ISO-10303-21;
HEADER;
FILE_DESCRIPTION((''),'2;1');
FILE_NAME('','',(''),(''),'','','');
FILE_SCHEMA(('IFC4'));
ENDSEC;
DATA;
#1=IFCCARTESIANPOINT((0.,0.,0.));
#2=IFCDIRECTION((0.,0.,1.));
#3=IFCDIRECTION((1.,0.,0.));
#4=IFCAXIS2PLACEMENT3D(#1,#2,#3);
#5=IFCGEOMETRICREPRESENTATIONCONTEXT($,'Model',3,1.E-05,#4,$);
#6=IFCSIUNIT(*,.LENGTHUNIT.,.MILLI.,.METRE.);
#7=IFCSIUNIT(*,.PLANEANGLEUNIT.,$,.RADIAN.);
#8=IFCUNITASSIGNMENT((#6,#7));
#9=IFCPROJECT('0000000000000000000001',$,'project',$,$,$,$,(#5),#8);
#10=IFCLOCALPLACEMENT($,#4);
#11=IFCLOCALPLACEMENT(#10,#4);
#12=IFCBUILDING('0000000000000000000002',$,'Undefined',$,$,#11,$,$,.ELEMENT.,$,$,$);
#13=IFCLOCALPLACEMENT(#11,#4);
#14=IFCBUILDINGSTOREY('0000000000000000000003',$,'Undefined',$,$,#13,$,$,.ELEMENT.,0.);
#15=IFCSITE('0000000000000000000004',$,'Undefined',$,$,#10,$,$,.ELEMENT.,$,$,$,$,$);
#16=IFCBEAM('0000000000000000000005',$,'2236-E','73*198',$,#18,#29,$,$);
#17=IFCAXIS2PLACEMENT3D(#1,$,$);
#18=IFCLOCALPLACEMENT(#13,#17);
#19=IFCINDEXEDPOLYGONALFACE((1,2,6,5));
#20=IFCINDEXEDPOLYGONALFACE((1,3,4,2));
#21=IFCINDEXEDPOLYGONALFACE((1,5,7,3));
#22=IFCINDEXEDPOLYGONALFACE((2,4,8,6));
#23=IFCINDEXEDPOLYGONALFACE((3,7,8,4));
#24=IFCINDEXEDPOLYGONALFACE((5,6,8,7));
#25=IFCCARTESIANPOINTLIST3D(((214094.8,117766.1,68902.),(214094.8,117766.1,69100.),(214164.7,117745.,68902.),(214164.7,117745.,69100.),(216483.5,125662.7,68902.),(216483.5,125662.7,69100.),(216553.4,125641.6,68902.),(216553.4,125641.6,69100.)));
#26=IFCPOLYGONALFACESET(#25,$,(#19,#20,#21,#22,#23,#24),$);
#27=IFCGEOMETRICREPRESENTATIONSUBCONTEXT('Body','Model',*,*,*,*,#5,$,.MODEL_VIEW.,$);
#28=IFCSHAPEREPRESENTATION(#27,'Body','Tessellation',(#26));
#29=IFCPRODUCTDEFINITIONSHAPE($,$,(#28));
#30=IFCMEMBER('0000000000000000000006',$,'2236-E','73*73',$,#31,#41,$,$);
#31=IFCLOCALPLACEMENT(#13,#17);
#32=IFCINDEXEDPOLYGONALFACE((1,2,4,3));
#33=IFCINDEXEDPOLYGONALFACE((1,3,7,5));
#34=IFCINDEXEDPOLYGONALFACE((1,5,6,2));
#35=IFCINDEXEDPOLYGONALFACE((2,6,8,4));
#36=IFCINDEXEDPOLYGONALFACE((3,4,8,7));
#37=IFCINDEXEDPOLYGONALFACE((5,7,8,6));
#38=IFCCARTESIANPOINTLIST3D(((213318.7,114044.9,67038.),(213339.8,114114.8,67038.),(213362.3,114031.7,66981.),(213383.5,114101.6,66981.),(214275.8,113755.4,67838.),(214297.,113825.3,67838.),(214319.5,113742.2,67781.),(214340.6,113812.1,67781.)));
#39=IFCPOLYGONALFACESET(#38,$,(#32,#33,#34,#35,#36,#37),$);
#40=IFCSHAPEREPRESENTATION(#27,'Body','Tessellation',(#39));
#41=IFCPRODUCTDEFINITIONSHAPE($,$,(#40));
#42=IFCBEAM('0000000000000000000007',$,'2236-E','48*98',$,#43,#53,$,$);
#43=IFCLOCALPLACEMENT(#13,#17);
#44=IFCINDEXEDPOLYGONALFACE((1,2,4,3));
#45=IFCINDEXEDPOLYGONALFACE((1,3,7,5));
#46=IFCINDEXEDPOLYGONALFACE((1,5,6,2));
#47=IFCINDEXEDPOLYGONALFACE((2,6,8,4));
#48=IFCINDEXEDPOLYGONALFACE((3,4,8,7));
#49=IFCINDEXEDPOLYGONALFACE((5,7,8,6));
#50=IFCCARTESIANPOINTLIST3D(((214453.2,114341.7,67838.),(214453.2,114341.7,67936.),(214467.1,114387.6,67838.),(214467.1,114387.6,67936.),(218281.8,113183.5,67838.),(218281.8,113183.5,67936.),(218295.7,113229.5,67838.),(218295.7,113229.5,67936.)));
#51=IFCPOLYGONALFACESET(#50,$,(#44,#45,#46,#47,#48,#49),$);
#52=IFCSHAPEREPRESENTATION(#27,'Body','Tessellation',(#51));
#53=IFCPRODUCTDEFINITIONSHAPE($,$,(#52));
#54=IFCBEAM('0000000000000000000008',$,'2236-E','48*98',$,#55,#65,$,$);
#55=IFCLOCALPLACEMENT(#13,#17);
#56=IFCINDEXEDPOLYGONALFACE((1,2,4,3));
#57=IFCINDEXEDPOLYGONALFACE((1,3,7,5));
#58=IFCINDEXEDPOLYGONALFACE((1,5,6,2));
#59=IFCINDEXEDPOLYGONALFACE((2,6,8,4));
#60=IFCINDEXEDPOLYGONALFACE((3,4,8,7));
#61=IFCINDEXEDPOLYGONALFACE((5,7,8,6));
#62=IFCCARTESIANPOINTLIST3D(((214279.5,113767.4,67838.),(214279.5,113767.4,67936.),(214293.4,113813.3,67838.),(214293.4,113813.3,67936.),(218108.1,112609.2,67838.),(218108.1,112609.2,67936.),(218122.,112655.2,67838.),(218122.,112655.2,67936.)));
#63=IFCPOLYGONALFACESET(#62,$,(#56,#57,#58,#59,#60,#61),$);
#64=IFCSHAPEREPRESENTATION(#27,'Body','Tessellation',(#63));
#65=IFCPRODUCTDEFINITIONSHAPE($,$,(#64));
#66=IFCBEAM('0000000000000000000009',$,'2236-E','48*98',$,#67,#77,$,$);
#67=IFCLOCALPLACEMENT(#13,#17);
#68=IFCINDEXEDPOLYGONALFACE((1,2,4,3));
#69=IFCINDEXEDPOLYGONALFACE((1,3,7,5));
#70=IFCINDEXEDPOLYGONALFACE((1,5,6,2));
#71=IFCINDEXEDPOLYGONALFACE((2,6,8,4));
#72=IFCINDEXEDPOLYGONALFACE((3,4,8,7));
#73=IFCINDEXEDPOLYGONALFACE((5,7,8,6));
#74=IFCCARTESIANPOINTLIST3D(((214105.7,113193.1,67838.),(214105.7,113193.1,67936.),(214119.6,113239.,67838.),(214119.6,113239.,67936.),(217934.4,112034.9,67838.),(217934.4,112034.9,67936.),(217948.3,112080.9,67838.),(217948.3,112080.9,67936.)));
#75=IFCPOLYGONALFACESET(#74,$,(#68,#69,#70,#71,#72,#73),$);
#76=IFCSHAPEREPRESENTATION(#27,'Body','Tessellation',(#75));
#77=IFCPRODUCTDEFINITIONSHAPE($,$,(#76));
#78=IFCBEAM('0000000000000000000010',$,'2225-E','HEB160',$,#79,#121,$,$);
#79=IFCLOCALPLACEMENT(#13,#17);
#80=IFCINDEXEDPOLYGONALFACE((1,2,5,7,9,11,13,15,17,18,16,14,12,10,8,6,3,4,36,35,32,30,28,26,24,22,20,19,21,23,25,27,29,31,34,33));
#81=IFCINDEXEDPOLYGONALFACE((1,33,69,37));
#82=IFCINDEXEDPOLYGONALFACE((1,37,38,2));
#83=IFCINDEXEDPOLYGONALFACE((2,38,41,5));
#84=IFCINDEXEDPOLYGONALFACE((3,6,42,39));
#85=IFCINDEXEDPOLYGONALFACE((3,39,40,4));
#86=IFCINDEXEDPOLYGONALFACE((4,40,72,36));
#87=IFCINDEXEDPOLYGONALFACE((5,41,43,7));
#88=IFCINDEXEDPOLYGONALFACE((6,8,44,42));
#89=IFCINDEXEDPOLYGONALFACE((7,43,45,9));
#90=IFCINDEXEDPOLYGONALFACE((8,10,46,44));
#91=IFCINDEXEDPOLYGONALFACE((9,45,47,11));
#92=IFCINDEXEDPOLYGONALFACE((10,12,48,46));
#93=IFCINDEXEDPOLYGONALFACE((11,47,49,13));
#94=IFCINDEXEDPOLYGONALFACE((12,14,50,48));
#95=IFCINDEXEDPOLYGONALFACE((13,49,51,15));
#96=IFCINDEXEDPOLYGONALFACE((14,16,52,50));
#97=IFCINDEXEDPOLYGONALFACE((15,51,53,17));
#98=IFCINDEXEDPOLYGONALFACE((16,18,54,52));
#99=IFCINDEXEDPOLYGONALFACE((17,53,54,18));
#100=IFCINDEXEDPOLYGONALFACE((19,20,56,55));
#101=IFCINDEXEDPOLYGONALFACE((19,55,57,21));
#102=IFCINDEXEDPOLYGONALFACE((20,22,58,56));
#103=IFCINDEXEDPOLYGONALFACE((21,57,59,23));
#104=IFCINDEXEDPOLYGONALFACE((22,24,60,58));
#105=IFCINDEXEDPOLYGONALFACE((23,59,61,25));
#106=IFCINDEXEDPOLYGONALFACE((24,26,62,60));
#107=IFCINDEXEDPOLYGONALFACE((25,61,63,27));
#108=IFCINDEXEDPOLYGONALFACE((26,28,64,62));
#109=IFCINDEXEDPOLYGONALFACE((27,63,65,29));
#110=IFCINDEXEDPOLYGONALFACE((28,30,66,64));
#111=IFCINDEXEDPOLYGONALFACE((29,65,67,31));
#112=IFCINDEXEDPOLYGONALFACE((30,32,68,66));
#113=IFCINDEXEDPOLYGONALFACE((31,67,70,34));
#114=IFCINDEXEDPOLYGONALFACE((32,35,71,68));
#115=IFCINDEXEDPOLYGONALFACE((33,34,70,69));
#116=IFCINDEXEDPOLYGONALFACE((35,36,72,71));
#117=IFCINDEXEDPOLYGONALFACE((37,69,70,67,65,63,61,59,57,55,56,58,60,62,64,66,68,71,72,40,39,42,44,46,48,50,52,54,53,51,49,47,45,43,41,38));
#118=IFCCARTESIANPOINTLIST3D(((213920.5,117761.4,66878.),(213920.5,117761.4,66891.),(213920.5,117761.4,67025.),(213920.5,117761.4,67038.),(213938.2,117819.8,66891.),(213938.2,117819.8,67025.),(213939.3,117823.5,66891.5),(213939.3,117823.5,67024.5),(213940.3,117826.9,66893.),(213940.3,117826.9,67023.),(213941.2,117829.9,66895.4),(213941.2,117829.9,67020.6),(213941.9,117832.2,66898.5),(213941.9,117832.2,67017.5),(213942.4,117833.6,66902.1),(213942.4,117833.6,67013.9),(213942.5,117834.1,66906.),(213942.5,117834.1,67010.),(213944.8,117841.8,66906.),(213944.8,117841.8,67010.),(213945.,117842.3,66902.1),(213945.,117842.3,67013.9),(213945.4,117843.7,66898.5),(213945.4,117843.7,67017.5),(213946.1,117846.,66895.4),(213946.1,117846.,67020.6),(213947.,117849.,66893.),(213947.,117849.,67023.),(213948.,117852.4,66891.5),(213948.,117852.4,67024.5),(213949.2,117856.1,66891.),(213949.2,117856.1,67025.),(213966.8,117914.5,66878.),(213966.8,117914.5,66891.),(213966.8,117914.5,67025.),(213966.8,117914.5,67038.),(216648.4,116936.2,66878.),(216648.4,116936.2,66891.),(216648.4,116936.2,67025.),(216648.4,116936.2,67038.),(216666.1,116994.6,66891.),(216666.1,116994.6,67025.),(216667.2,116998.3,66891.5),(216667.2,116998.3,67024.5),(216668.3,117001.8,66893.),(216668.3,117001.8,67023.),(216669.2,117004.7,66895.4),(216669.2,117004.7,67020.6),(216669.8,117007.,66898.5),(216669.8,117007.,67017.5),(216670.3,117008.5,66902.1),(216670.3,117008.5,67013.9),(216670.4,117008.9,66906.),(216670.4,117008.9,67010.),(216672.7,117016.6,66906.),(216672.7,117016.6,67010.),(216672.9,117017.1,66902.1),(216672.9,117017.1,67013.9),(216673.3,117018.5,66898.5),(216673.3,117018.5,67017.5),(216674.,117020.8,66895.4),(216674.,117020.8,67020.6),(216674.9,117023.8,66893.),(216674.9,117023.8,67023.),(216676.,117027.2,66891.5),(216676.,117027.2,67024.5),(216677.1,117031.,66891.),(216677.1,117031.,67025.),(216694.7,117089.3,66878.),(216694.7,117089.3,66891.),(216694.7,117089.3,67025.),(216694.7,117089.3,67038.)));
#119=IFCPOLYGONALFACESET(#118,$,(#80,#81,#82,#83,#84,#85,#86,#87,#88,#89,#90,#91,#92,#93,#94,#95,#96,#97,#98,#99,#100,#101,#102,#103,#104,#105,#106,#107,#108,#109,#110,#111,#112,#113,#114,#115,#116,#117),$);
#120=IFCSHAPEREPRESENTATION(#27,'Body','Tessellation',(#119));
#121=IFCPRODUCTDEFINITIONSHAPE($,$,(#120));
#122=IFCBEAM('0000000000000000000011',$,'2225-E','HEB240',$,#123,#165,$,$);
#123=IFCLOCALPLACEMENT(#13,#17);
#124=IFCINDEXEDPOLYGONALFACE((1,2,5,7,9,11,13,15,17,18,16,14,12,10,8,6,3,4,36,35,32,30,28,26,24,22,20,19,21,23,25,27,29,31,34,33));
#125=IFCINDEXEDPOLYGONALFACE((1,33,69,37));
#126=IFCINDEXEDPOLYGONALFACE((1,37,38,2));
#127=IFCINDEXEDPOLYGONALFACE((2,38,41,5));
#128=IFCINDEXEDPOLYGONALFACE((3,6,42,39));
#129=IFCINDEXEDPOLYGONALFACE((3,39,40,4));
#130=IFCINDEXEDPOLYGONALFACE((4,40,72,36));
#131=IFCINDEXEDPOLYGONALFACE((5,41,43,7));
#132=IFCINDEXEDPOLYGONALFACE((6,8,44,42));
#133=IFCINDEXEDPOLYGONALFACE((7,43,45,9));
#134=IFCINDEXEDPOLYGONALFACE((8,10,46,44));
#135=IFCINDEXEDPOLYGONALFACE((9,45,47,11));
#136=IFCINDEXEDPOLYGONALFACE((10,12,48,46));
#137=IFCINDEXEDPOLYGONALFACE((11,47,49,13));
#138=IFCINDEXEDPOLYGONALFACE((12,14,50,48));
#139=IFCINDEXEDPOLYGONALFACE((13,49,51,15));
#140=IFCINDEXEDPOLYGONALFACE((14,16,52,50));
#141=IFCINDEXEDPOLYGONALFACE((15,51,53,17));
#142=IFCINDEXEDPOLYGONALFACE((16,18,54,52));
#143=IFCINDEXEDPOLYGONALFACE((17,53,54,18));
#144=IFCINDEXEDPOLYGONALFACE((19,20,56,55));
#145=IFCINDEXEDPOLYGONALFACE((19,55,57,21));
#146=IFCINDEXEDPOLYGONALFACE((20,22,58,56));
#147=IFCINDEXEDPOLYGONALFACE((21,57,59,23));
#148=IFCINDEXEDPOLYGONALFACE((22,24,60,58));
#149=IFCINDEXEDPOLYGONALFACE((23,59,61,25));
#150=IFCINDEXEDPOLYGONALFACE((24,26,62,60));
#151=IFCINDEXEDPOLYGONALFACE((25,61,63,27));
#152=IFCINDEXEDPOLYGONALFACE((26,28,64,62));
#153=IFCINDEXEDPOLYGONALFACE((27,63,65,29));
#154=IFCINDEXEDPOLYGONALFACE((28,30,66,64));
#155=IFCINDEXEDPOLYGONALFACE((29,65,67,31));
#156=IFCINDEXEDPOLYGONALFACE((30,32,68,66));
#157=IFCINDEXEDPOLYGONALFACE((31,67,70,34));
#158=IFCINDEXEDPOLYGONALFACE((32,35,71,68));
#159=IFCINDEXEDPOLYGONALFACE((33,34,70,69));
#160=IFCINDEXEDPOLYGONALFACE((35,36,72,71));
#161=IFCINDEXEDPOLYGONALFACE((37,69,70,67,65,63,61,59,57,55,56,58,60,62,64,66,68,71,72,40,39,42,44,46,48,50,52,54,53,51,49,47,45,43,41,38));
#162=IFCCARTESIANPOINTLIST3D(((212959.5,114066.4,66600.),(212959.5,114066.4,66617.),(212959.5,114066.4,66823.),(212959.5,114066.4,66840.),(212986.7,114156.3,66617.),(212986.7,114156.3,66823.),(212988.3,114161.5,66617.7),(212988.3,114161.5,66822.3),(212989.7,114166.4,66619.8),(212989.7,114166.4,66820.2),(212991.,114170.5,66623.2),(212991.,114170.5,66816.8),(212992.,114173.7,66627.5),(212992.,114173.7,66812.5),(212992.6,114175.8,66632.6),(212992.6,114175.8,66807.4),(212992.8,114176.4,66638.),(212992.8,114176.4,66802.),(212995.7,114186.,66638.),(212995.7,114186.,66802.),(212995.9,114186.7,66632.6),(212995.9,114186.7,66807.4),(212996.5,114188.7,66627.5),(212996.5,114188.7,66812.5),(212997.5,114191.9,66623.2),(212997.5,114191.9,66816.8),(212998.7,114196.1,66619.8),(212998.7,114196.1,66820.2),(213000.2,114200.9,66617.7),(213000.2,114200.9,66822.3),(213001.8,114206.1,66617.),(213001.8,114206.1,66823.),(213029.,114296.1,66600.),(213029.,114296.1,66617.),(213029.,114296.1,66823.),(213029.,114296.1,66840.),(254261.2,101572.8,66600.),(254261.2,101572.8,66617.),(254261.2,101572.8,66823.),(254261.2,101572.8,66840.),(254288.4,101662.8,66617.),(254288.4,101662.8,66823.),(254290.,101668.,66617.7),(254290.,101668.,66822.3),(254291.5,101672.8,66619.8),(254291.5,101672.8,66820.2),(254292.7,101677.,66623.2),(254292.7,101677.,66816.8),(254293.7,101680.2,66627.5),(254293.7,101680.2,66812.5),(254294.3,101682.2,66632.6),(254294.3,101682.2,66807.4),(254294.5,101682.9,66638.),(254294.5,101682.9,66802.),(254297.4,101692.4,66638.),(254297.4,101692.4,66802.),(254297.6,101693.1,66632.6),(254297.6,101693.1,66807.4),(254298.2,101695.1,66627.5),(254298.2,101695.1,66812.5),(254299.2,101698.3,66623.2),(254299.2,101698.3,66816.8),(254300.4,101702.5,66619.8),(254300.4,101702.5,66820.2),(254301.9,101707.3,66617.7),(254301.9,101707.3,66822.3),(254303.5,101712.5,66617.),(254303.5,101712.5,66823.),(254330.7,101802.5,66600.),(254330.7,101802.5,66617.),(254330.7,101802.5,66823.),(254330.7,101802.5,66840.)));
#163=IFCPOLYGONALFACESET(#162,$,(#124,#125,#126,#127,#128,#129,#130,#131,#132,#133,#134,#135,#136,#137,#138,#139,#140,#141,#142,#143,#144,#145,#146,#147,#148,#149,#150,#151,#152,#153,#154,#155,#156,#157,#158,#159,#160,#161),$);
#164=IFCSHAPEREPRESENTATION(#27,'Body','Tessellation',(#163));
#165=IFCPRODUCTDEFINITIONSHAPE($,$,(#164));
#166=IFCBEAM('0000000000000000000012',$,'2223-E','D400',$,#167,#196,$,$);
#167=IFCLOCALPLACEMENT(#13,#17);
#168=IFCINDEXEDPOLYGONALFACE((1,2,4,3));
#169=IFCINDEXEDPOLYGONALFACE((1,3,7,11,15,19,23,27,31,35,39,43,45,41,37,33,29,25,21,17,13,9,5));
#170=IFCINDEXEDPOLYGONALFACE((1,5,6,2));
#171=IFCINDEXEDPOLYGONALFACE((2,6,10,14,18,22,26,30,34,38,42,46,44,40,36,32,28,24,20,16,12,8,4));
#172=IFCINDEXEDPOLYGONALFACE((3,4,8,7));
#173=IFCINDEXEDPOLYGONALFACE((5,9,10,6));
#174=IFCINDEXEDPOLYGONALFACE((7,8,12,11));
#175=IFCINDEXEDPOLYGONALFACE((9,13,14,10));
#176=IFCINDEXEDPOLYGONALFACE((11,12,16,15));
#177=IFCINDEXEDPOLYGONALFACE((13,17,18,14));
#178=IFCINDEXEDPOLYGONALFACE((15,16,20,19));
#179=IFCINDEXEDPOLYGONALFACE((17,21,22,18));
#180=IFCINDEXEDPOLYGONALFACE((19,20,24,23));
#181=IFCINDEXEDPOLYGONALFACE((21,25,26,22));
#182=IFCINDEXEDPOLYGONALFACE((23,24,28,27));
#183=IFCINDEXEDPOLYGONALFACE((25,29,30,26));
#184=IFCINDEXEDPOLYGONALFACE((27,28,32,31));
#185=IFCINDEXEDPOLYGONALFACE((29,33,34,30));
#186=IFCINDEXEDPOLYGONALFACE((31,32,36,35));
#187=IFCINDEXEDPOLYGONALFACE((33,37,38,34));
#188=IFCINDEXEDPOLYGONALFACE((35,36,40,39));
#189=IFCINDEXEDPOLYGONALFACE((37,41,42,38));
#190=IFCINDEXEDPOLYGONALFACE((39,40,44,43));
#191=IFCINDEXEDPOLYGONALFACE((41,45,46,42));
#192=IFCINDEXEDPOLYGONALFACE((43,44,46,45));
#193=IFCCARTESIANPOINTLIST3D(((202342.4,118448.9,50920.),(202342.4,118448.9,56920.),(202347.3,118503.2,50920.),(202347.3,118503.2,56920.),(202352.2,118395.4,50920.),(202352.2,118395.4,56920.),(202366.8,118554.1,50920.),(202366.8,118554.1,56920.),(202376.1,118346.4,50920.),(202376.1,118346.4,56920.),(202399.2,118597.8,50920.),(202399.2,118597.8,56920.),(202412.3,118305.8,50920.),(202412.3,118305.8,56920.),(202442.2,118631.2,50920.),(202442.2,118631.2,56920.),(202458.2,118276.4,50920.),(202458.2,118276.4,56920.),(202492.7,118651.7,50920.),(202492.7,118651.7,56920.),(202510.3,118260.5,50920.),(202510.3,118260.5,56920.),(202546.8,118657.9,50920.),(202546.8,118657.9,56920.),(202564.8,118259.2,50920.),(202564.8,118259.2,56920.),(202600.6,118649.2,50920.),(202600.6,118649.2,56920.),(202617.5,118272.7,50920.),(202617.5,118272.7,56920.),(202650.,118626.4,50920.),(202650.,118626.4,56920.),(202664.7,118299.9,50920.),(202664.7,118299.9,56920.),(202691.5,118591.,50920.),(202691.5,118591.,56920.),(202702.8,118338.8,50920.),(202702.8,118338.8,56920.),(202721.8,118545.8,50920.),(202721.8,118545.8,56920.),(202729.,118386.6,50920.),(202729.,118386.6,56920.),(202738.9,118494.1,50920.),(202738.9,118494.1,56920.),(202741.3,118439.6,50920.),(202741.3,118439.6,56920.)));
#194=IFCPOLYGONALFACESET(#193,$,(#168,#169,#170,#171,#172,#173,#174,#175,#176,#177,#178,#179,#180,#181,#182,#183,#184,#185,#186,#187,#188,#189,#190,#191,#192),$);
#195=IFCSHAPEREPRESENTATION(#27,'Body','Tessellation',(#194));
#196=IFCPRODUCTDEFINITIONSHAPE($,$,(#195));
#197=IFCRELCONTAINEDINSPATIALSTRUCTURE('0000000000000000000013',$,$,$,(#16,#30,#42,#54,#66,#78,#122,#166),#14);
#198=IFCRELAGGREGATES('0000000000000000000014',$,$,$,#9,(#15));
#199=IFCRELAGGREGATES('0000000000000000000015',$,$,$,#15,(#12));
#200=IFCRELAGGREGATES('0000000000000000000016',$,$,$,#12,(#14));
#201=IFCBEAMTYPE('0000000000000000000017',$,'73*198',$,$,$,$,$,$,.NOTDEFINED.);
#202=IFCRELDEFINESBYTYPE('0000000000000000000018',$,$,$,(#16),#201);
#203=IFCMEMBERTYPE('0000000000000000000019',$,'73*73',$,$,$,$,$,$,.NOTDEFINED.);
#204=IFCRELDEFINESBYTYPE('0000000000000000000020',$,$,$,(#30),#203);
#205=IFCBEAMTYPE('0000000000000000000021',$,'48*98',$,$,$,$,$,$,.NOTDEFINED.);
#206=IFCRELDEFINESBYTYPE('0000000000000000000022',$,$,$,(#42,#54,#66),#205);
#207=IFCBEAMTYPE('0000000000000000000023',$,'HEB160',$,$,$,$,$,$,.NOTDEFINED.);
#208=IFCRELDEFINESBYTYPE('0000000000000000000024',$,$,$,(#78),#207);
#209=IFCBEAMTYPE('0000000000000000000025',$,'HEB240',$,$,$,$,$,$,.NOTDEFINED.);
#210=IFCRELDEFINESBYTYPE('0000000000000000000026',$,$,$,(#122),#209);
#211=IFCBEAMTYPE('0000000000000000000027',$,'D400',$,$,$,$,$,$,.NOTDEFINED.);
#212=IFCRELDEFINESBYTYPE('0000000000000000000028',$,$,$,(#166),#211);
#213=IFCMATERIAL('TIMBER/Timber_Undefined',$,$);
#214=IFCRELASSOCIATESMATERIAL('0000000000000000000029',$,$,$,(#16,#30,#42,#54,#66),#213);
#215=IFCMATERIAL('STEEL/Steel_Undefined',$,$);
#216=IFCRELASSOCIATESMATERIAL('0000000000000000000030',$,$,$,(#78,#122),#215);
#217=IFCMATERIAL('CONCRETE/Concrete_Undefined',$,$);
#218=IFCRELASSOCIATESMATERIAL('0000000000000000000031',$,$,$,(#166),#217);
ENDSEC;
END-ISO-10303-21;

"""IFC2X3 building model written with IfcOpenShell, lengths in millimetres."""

from ifc_helpers import new_model, si_unit, frame, origin_with_axes, origin_2d_with_axis, place, context, subcontext, project, spatial, rectangle, circle, i_section, extrude, material, type_object, element, save


model = new_model("IFC2X3")

# Units and contexts
model_context = context("Model", 3, precision=1e-05, world=origin_with_axes())
body_context = subcontext(model_context, "Body", "Model", "MODEL_VIEW")
ifc_project = project(units=[si_unit("LENGTHUNIT", "METRE", prefix="MILLI"), si_unit("PLANEANGLEUNIT", "RADIAN")], contexts=[model_context])

# Site, building, storey
site_placement = place(None, origin_with_axes())
site = spatial("IfcSite", under=ifc_project, at=site_placement, Name="Undefined", CompositionType="ELEMENT")
building_placement = place(site_placement, origin_with_axes())
building = spatial("IfcBuilding", under=site, at=building_placement, Name="Undefined", CompositionType="ELEMENT")
storey_placement = place(building_placement, origin_with_axes())
storey = spatial("IfcBuildingStorey", under=building, at=storey_placement, Name="Undefined", CompositionType="ELEMENT", Elevation=0.0)

# Shared definitions
ifc_material_1 = material(Name="TIMBER/Timber_Undefined")
ifc_material_2 = material(Name="STEEL/Steel_Undefined")

# Beam
beam_type_1 = type_object("IfcBeamType", Name="73*198", PredefinedType="NOTDEFINED")
beam_1_placement = place(storey_placement, frame((214129.8, 117755.5, 69001.0), z_axis=(-0.957167, 0.289538, 0.0), x_axis=(0.289538, 0.957166, 0.0)))
element("IfcBeam", 1, at=beam_1_placement, inside=storey, type_object=beam_type_1, material=ifc_material_1, Name="2236-E", Description="73*198", context=body_context, shape_type="SweptSolid", body=[
    extrude(rectangle(XDim=198.0, YDim=73.0, at=origin_2d_with_axis()), frame((8250.0, 0.0, 0.0), z_axis=(-1.0, 0.0, 0.0), x_axis=(0.0, -1.0, 0.0)), (0.0, 0.0, 1.0), 8250.0),
])

# Member
member_type_1 = type_object("IfcMemberType", Name="73*73", PredefinedType="NOTDEFINED")
member_1_placement = place(storey_placement, frame((214308.2, 113783.7, 67809.5), z_axis=(0.289538, 0.957166, 0.0), x_axis=(-0.747421, 0.226091, -0.624695)))
element("IfcMember", 2, at=member_1_placement, inside=storey, type_object=member_type_1, material=ifc_material_1, Name="2236-E", Description="73*73", context=body_context, shape_type="SweptSolid", body=[
    extrude(rectangle(XDim=73.0, YDim=73.0, at=origin_2d_with_axis()), frame((1280.6, 0.0, 0.0), z_axis=(-1.0, 0.0, 0.0), x_axis=(0.0, -1.0, 0.0)), (0.0, 0.0, 1.0), 1280.6),
])

# Beams
beam_type_2 = type_object("IfcBeamType", Name="48*98", PredefinedType="NOTDEFINED")
for number, where, z_axis, x_axis, name in (
    (3, (214460.1, 114364.6, 67887.0), (0.289538, 0.957166, 0.0), (0.957167, -0.289538, 0.0), "2236-E"),
    (4, (214286.4, 113790.3, 67887.0), (0.289538, 0.957166, 0.0), (0.957167, -0.289538, 0.0), "2236-E"),
    (5, (214112.7, 113216.0, 67887.0), (0.289538, 0.957166, 0.0), (0.957167, -0.289538, 0.0), "2236-E"),
):
    element("IfcBeam", number, at=place(storey_placement, frame(where, z_axis=z_axis, x_axis=x_axis)), inside=storey, type_object=beam_type_2, material=ifc_material_1, Name=name, Description="48*98", context=body_context, shape_type="SweptSolid", body=[
        extrude(rectangle(XDim=98.0, YDim=48.0, at=origin_2d_with_axis()), frame((4000.0, 0.0, 0.0), z_axis=(-1.0, 0.0, 0.0), x_axis=(0.0, -1.0, 0.0)), (0.0, 0.0, 1.0), 4000.0),
    ])
beam_type_3 = type_object("IfcBeamType", Name="HEB160", PredefinedType="NOTDEFINED")
beam_2_placement = place(storey_placement, frame((213943.7, 117838.0, 66958.0), z_axis=(0.0, 0.0, 1.0), x_axis=(0.957167, -0.289538, 0.0)))
element("IfcBeam", 6, at=beam_2_placement, inside=storey, type_object=beam_type_3, material=ifc_material_2, Name="2225-E", Description="HEB160", context=body_context, shape_type="SweptSolid", body=[
    extrude(i_section(OverallWidth=160.0, OverallDepth=160.0, WebThickness=8.0, FlangeThickness=13.0, FilletRadius=15.0, at=origin_2d_with_axis()), frame((2850.0, 0.0, 0.0), z_axis=(-1.0, 0.0, 0.0), x_axis=(0.0, -1.0, 0.0)), (0.0, 0.0, 1.0), 2850.0),
])
beam_type_4 = type_object("IfcBeamType", Name="HEB240", PredefinedType="NOTDEFINED")
beam_3_placement = place(storey_placement, frame((212994.2, 114181.2, 66720.0), z_axis=(0.0, 0.0, 1.0), x_axis=(0.957167, -0.289538, 0.0)))
element("IfcBeam", 7, at=beam_3_placement, inside=storey, type_object=beam_type_4, material=ifc_material_2, Name="2225-E", Description="HEB240", context=body_context, shape_type="SweptSolid", body=[
    extrude(i_section(OverallWidth=240.0, OverallDepth=240.0, WebThickness=10.0, FlangeThickness=17.0, FilletRadius=21.0, at=origin_2d_with_axis()), frame((43150.0, 0.0, 0.0), z_axis=(-1.0, 0.0, 0.0), x_axis=(0.0, -1.0, 0.0)), (0.0, 0.0, 1.0), 43150.0),
])
ifc_material_3 = material(Name="CONCRETE/Concrete_Undefined")
beam_type_5 = type_object("IfcBeamType", Name="D400", PredefinedType="NOTDEFINED")
for number, where, z_axis, x_axis, name in (
    (8, (202542.2, 118457.9, 50920.0), (0.999728, -0.023321, 0.0), (0.0, 0.0, 1.0), "2223-E"),
):
    element("IfcBeam", number, at=place(storey_placement, frame(where, z_axis=z_axis, x_axis=x_axis)), inside=storey, type_object=beam_type_5, material=ifc_material_3, Name=name, Description="D400", context=body_context, shape_type="SweptSolid", body=[
        extrude(circle(Radius=200.0, at=origin_2d_with_axis()), frame((6000.0, 0.0, 0.0), z_axis=(-1.0, 0.0, 0.0), x_axis=(0.0, -1.0, 0.0)), (0.0, 0.0, 1.0), 6000.0),
    ])

save(model, "model.ifc")
